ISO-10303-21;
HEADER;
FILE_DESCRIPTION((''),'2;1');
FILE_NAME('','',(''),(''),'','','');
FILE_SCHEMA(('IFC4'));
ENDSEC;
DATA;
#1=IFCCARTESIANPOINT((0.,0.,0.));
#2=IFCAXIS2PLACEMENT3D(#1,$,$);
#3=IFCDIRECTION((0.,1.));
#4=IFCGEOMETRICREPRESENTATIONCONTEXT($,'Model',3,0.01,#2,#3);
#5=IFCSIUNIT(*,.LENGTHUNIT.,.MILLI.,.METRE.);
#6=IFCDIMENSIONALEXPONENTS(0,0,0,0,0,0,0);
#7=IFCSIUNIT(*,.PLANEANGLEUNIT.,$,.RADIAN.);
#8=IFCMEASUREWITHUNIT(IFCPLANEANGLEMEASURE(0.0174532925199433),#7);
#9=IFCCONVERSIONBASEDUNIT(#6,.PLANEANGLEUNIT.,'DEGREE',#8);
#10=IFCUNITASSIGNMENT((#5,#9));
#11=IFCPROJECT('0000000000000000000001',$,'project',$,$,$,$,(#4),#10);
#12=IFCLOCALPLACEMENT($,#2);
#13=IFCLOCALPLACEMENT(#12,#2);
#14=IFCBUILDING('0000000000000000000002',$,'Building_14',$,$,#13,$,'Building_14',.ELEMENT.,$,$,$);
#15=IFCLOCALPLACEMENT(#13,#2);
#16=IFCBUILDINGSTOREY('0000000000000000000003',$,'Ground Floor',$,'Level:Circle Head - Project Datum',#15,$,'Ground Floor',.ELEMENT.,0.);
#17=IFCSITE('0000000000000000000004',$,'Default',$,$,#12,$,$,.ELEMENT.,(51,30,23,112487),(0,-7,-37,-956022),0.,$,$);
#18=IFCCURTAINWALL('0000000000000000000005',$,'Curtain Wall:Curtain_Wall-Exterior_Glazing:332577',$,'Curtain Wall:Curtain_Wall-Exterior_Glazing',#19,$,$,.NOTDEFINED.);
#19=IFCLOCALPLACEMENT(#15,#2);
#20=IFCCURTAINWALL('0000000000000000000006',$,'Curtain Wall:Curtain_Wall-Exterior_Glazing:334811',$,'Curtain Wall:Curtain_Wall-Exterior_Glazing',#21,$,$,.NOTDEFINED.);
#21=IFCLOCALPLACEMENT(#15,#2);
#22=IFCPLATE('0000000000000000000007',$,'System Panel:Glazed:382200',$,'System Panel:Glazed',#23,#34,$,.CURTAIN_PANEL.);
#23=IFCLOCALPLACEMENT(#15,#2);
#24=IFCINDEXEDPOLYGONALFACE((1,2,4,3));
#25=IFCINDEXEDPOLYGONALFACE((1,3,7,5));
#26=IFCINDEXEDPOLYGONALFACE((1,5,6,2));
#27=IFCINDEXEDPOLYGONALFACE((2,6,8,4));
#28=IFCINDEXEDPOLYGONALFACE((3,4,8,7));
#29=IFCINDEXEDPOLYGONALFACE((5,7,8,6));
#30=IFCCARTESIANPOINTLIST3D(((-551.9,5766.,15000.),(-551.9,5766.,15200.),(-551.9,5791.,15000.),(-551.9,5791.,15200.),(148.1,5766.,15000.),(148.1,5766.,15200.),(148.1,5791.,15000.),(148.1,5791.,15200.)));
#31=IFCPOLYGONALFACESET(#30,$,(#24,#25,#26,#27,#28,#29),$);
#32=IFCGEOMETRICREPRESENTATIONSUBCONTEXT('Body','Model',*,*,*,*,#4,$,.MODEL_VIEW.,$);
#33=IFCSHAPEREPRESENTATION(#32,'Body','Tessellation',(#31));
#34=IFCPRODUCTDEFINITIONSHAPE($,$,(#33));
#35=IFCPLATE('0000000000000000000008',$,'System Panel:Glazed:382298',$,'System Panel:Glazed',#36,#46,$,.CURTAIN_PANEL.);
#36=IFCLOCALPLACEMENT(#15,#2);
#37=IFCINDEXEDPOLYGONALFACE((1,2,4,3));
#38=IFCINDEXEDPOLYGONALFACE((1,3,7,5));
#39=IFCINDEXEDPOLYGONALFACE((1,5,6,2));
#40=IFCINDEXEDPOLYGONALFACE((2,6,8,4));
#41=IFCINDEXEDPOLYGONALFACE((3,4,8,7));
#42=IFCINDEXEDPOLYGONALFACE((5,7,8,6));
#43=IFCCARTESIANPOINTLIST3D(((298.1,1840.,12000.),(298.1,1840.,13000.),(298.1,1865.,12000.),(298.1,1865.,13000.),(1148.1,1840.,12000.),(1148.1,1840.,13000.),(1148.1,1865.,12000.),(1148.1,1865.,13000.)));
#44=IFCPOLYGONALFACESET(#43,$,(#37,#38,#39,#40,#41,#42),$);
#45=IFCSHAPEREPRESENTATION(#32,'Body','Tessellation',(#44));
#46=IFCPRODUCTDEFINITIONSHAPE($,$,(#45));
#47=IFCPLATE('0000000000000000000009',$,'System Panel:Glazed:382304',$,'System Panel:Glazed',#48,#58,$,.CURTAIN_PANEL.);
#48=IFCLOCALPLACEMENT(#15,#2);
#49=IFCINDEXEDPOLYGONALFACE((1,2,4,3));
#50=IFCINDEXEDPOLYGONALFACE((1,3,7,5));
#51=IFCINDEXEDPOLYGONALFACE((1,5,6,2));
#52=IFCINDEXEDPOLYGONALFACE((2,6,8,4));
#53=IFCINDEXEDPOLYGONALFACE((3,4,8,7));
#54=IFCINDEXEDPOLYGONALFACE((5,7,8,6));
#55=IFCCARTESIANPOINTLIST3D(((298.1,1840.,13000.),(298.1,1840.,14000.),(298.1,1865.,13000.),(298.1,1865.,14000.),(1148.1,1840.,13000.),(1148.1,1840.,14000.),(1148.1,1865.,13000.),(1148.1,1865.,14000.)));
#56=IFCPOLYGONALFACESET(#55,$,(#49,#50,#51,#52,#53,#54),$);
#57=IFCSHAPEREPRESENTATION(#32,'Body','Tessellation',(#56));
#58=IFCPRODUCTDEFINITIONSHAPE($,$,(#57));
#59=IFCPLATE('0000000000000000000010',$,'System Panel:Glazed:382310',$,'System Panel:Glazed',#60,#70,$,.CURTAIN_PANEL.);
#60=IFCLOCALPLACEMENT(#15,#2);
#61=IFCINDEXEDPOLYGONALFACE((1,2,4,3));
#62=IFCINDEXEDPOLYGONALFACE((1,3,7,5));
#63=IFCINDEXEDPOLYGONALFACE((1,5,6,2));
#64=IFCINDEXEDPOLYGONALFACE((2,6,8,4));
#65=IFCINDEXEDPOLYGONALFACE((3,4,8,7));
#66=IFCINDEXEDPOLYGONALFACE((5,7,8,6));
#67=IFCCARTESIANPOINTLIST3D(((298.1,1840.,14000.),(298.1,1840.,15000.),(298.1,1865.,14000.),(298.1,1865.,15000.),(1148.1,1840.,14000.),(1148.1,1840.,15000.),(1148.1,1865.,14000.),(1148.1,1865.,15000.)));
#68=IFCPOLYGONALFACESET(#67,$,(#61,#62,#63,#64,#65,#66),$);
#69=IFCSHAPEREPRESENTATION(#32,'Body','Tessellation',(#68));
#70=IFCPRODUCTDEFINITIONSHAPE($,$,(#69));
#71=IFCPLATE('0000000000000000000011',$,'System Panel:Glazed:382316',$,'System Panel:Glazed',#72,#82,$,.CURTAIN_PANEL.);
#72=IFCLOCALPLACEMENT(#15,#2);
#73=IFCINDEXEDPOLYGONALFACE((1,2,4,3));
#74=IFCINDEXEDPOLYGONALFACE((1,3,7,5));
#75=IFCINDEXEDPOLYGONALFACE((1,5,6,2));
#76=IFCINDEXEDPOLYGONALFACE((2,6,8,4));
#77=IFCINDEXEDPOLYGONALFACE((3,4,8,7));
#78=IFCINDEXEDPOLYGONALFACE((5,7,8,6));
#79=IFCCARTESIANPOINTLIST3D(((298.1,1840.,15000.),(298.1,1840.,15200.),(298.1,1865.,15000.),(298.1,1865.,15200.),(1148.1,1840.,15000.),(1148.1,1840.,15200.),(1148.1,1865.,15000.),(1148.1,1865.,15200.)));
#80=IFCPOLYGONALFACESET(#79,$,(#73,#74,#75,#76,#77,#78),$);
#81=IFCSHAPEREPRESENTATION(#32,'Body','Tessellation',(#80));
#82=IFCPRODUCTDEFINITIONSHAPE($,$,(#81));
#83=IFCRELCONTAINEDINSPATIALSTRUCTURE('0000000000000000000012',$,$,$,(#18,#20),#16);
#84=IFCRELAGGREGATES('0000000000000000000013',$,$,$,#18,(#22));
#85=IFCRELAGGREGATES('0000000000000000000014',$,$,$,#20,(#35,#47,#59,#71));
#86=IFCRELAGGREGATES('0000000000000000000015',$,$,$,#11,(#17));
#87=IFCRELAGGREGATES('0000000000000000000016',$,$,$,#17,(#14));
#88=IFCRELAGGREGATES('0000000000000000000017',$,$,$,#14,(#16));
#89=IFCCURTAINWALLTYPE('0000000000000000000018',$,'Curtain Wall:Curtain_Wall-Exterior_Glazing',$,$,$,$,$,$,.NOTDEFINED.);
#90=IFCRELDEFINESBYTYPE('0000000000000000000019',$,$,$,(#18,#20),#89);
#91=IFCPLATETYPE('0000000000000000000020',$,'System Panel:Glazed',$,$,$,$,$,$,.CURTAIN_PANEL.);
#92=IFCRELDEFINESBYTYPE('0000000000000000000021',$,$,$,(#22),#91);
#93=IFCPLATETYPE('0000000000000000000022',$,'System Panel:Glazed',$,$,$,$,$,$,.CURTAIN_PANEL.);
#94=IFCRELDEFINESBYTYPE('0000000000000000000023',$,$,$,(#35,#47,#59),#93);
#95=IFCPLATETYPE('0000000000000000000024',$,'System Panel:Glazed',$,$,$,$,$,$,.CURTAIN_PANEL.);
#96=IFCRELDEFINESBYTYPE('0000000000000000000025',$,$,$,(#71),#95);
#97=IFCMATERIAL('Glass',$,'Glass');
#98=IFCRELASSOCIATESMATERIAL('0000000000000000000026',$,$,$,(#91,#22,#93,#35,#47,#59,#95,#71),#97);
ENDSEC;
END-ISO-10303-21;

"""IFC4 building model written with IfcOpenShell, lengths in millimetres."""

from ifc_helpers import new_model, entity, si_unit, converted_unit, direction, frame, origin, place, context, subcontext, project, spatial, indexed_curve, outline, extrude, source, transform, mapped, material, type_object, type_shapes, element, aggregate, save


model = new_model("IFC4")

# Units and contexts
model_context = context("Model", 3, precision=0.01, world=origin(), true_north=direction((0.0, 1.0)))
body_context = subcontext(model_context, "Body", "Model", "MODEL_VIEW")
ifc_project = project(units=[si_unit("LENGTHUNIT", "METRE", prefix="MILLI"), converted_unit("PLANEANGLEUNIT", "DEGREE", entity("IfcPlaneAngleMeasure", 0.0174532925199433), si_unit("PLANEANGLEUNIT", "RADIAN"), dimensions=[0, 0, 0, 0, 0, 0, 0])], contexts=[model_context])

# Site, building, storey
site_placement = place(None, origin())
site = spatial("IfcSite", under=ifc_project, at=site_placement, Name="Default", CompositionType="ELEMENT", RefLatitude=(51, 30, 23, 112487), RefLongitude=(0, -7, -37, -956022), RefElevation=0.0)
building_placement = place(site_placement, origin())
building = spatial("IfcBuilding", under=site, at=building_placement, Name="Building_14", LongName="Building_14", CompositionType="ELEMENT")
storey_placement = place(building_placement, origin())
storey = spatial("IfcBuildingStorey", under=building, at=storey_placement, Name="Ground Floor", ObjectType="Level:Circle Head - Project Datum", LongName="Ground Floor", CompositionType="ELEMENT", Elevation=0.0)

# Curtain walls
curtain_wall_type = type_object("IfcCurtainWallType", Name="Curtain Wall:Curtain_Wall-Exterior_Glazing", PredefinedType="NOTDEFINED")
curtain_wall_1_placement = place(storey_placement, origin())
curtain_wall_1 = element("IfcCurtainWall", 1, at=curtain_wall_1_placement, inside=storey, type_object=curtain_wall_type, Name="Curtain Wall:Curtain_Wall-Exterior_Glazing:332577", ObjectType="Curtain Wall:Curtain_Wall-Exterior_Glazing", PredefinedType="NOTDEFINED")
ifc_material = material(Name="Glass", Category="Glass")
curtain_wall_2_placement = place(storey_placement, origin())
curtain_wall_2 = element("IfcCurtainWall", 2, at=curtain_wall_2_placement, inside=storey, type_object=curtain_wall_type, Name="Curtain Wall:Curtain_Wall-Exterior_Glazing:334811", ObjectType="Curtain Wall:Curtain_Wall-Exterior_Glazing", PredefinedType="NOTDEFINED")

# Plates
plate_type_1 = type_object("IfcPlateType", Name="System Panel:Glazed", PredefinedType="CURTAIN_PANEL", material=ifc_material)
shared_shape_1 = source(origin(), body_context, "Body", "SweptSolid", [
    extrude(outline(indexed_curve([(-12.5, -350.0), (12.5, -350.0), (12.5, 350.0), (-12.5, 350.0), (-12.5, -350.0)], self_intersect=False)), frame((0.0, -37.0, 0.0), z_axis=(0.0, 0.0, 1.0), x_axis=(0.0, 1.0, 0.0)), (0.0, 0.0, 1.0), 200.0),
])
type_shapes(plate_type_1, [shared_shape_1])
plate_1_placement = place(curtain_wall_1_placement, frame((-201.9, 5815.5, 15000.0)))
plate_1 = element("IfcPlate", 3, at=plate_1_placement, type_object=plate_type_1, material=ifc_material, Name="System Panel:Glazed:382200", ObjectType="System Panel:Glazed", PredefinedType="CURTAIN_PANEL", context=body_context, shape_type="MappedRepresentation", body=[
    mapped(shared_shape_1, transform((0.0, 0.0, 0.0), scale=1.0)),
])
aggregate(curtain_wall_1, [plate_1])
plate_type_2 = type_object("IfcPlateType", Name="System Panel:Glazed", PredefinedType="CURTAIN_PANEL", material=ifc_material)
shared_shape_2 = source(origin(), body_context, "Body", "SweptSolid", [
    extrude(outline(indexed_curve([(-12.5, -425.0), (12.5, -425.0), (12.5, 425.0), (-12.5, 425.0), (-12.5, -425.0)], self_intersect=False)), frame((0.0, -37.0, 0.0), z_axis=(0.0, 0.0, 1.0), x_axis=(0.0, 1.0, 0.0)), (0.0, 0.0, 1.0), 1000.0),
])
type_shapes(plate_type_2, [shared_shape_2])
plate_2_placement = place(curtain_wall_2_placement, frame((723.1, 1815.5, 12000.0), z_axis=(0.0, 0.0, 1.0), x_axis=(-1.0, 0.0, 0.0)))
plate_2 = element("IfcPlate", 4, at=plate_2_placement, type_object=plate_type_2, material=ifc_material, Name="System Panel:Glazed:382298", ObjectType="System Panel:Glazed", PredefinedType="CURTAIN_PANEL", context=body_context, shape_type="MappedRepresentation", body=[
    mapped(shared_shape_2, transform((0.0, 0.0, 0.0), scale=1.0)),
])
plate_3_placement = place(curtain_wall_2_placement, frame((723.1, 1815.5, 13000.0), z_axis=(0.0, 0.0, 1.0), x_axis=(-1.0, 0.0, 0.0)))
plate_3 = element("IfcPlate", 5, at=plate_3_placement, type_object=plate_type_2, material=ifc_material, Name="System Panel:Glazed:382304", ObjectType="System Panel:Glazed", PredefinedType="CURTAIN_PANEL", context=body_context, shape_type="MappedRepresentation", body=[
    mapped(shared_shape_2, transform((0.0, 0.0, 0.0), scale=1.0)),
])
plate_4_placement = place(curtain_wall_2_placement, frame((723.1, 1815.5, 14000.0), z_axis=(0.0, 0.0, 1.0), x_axis=(-1.0, 0.0, 0.0)))
plate_4 = element("IfcPlate", 6, at=plate_4_placement, type_object=plate_type_2, material=ifc_material, Name="System Panel:Glazed:382310", ObjectType="System Panel:Glazed", PredefinedType="CURTAIN_PANEL", context=body_context, shape_type="MappedRepresentation", body=[
    mapped(shared_shape_2, transform((0.0, 0.0, 0.0), scale=1.0)),
])
plate_type_3 = type_object("IfcPlateType", Name="System Panel:Glazed", PredefinedType="CURTAIN_PANEL", material=ifc_material)
shared_shape_3 = source(origin(), body_context, "Body", "SweptSolid", [
    extrude(outline(indexed_curve([(-12.5, -425.0), (12.5, -425.0), (12.5, 425.0), (-12.5, 425.0), (-12.5, -425.0)], self_intersect=False)), frame((0.0, -37.0, 0.0), z_axis=(0.0, 0.0, 1.0), x_axis=(0.0, 1.0, 0.0)), (0.0, 0.0, 1.0), 200.0),
])
type_shapes(plate_type_3, [shared_shape_3])
plate_5_placement = place(curtain_wall_2_placement, frame((723.1, 1815.5, 15000.0), z_axis=(0.0, 0.0, 1.0), x_axis=(-1.0, 0.0, 0.0)))
plate_5 = element("IfcPlate", 7, at=plate_5_placement, type_object=plate_type_3, material=ifc_material, Name="System Panel:Glazed:382316", ObjectType="System Panel:Glazed", PredefinedType="CURTAIN_PANEL", context=body_context, shape_type="MappedRepresentation", body=[
    mapped(shared_shape_3, transform((0.0, 0.0, 0.0), scale=1.0)),
])
aggregate(curtain_wall_2, [plate_2, plate_3, plate_4, plate_5])

save(model, "model.ifc")
